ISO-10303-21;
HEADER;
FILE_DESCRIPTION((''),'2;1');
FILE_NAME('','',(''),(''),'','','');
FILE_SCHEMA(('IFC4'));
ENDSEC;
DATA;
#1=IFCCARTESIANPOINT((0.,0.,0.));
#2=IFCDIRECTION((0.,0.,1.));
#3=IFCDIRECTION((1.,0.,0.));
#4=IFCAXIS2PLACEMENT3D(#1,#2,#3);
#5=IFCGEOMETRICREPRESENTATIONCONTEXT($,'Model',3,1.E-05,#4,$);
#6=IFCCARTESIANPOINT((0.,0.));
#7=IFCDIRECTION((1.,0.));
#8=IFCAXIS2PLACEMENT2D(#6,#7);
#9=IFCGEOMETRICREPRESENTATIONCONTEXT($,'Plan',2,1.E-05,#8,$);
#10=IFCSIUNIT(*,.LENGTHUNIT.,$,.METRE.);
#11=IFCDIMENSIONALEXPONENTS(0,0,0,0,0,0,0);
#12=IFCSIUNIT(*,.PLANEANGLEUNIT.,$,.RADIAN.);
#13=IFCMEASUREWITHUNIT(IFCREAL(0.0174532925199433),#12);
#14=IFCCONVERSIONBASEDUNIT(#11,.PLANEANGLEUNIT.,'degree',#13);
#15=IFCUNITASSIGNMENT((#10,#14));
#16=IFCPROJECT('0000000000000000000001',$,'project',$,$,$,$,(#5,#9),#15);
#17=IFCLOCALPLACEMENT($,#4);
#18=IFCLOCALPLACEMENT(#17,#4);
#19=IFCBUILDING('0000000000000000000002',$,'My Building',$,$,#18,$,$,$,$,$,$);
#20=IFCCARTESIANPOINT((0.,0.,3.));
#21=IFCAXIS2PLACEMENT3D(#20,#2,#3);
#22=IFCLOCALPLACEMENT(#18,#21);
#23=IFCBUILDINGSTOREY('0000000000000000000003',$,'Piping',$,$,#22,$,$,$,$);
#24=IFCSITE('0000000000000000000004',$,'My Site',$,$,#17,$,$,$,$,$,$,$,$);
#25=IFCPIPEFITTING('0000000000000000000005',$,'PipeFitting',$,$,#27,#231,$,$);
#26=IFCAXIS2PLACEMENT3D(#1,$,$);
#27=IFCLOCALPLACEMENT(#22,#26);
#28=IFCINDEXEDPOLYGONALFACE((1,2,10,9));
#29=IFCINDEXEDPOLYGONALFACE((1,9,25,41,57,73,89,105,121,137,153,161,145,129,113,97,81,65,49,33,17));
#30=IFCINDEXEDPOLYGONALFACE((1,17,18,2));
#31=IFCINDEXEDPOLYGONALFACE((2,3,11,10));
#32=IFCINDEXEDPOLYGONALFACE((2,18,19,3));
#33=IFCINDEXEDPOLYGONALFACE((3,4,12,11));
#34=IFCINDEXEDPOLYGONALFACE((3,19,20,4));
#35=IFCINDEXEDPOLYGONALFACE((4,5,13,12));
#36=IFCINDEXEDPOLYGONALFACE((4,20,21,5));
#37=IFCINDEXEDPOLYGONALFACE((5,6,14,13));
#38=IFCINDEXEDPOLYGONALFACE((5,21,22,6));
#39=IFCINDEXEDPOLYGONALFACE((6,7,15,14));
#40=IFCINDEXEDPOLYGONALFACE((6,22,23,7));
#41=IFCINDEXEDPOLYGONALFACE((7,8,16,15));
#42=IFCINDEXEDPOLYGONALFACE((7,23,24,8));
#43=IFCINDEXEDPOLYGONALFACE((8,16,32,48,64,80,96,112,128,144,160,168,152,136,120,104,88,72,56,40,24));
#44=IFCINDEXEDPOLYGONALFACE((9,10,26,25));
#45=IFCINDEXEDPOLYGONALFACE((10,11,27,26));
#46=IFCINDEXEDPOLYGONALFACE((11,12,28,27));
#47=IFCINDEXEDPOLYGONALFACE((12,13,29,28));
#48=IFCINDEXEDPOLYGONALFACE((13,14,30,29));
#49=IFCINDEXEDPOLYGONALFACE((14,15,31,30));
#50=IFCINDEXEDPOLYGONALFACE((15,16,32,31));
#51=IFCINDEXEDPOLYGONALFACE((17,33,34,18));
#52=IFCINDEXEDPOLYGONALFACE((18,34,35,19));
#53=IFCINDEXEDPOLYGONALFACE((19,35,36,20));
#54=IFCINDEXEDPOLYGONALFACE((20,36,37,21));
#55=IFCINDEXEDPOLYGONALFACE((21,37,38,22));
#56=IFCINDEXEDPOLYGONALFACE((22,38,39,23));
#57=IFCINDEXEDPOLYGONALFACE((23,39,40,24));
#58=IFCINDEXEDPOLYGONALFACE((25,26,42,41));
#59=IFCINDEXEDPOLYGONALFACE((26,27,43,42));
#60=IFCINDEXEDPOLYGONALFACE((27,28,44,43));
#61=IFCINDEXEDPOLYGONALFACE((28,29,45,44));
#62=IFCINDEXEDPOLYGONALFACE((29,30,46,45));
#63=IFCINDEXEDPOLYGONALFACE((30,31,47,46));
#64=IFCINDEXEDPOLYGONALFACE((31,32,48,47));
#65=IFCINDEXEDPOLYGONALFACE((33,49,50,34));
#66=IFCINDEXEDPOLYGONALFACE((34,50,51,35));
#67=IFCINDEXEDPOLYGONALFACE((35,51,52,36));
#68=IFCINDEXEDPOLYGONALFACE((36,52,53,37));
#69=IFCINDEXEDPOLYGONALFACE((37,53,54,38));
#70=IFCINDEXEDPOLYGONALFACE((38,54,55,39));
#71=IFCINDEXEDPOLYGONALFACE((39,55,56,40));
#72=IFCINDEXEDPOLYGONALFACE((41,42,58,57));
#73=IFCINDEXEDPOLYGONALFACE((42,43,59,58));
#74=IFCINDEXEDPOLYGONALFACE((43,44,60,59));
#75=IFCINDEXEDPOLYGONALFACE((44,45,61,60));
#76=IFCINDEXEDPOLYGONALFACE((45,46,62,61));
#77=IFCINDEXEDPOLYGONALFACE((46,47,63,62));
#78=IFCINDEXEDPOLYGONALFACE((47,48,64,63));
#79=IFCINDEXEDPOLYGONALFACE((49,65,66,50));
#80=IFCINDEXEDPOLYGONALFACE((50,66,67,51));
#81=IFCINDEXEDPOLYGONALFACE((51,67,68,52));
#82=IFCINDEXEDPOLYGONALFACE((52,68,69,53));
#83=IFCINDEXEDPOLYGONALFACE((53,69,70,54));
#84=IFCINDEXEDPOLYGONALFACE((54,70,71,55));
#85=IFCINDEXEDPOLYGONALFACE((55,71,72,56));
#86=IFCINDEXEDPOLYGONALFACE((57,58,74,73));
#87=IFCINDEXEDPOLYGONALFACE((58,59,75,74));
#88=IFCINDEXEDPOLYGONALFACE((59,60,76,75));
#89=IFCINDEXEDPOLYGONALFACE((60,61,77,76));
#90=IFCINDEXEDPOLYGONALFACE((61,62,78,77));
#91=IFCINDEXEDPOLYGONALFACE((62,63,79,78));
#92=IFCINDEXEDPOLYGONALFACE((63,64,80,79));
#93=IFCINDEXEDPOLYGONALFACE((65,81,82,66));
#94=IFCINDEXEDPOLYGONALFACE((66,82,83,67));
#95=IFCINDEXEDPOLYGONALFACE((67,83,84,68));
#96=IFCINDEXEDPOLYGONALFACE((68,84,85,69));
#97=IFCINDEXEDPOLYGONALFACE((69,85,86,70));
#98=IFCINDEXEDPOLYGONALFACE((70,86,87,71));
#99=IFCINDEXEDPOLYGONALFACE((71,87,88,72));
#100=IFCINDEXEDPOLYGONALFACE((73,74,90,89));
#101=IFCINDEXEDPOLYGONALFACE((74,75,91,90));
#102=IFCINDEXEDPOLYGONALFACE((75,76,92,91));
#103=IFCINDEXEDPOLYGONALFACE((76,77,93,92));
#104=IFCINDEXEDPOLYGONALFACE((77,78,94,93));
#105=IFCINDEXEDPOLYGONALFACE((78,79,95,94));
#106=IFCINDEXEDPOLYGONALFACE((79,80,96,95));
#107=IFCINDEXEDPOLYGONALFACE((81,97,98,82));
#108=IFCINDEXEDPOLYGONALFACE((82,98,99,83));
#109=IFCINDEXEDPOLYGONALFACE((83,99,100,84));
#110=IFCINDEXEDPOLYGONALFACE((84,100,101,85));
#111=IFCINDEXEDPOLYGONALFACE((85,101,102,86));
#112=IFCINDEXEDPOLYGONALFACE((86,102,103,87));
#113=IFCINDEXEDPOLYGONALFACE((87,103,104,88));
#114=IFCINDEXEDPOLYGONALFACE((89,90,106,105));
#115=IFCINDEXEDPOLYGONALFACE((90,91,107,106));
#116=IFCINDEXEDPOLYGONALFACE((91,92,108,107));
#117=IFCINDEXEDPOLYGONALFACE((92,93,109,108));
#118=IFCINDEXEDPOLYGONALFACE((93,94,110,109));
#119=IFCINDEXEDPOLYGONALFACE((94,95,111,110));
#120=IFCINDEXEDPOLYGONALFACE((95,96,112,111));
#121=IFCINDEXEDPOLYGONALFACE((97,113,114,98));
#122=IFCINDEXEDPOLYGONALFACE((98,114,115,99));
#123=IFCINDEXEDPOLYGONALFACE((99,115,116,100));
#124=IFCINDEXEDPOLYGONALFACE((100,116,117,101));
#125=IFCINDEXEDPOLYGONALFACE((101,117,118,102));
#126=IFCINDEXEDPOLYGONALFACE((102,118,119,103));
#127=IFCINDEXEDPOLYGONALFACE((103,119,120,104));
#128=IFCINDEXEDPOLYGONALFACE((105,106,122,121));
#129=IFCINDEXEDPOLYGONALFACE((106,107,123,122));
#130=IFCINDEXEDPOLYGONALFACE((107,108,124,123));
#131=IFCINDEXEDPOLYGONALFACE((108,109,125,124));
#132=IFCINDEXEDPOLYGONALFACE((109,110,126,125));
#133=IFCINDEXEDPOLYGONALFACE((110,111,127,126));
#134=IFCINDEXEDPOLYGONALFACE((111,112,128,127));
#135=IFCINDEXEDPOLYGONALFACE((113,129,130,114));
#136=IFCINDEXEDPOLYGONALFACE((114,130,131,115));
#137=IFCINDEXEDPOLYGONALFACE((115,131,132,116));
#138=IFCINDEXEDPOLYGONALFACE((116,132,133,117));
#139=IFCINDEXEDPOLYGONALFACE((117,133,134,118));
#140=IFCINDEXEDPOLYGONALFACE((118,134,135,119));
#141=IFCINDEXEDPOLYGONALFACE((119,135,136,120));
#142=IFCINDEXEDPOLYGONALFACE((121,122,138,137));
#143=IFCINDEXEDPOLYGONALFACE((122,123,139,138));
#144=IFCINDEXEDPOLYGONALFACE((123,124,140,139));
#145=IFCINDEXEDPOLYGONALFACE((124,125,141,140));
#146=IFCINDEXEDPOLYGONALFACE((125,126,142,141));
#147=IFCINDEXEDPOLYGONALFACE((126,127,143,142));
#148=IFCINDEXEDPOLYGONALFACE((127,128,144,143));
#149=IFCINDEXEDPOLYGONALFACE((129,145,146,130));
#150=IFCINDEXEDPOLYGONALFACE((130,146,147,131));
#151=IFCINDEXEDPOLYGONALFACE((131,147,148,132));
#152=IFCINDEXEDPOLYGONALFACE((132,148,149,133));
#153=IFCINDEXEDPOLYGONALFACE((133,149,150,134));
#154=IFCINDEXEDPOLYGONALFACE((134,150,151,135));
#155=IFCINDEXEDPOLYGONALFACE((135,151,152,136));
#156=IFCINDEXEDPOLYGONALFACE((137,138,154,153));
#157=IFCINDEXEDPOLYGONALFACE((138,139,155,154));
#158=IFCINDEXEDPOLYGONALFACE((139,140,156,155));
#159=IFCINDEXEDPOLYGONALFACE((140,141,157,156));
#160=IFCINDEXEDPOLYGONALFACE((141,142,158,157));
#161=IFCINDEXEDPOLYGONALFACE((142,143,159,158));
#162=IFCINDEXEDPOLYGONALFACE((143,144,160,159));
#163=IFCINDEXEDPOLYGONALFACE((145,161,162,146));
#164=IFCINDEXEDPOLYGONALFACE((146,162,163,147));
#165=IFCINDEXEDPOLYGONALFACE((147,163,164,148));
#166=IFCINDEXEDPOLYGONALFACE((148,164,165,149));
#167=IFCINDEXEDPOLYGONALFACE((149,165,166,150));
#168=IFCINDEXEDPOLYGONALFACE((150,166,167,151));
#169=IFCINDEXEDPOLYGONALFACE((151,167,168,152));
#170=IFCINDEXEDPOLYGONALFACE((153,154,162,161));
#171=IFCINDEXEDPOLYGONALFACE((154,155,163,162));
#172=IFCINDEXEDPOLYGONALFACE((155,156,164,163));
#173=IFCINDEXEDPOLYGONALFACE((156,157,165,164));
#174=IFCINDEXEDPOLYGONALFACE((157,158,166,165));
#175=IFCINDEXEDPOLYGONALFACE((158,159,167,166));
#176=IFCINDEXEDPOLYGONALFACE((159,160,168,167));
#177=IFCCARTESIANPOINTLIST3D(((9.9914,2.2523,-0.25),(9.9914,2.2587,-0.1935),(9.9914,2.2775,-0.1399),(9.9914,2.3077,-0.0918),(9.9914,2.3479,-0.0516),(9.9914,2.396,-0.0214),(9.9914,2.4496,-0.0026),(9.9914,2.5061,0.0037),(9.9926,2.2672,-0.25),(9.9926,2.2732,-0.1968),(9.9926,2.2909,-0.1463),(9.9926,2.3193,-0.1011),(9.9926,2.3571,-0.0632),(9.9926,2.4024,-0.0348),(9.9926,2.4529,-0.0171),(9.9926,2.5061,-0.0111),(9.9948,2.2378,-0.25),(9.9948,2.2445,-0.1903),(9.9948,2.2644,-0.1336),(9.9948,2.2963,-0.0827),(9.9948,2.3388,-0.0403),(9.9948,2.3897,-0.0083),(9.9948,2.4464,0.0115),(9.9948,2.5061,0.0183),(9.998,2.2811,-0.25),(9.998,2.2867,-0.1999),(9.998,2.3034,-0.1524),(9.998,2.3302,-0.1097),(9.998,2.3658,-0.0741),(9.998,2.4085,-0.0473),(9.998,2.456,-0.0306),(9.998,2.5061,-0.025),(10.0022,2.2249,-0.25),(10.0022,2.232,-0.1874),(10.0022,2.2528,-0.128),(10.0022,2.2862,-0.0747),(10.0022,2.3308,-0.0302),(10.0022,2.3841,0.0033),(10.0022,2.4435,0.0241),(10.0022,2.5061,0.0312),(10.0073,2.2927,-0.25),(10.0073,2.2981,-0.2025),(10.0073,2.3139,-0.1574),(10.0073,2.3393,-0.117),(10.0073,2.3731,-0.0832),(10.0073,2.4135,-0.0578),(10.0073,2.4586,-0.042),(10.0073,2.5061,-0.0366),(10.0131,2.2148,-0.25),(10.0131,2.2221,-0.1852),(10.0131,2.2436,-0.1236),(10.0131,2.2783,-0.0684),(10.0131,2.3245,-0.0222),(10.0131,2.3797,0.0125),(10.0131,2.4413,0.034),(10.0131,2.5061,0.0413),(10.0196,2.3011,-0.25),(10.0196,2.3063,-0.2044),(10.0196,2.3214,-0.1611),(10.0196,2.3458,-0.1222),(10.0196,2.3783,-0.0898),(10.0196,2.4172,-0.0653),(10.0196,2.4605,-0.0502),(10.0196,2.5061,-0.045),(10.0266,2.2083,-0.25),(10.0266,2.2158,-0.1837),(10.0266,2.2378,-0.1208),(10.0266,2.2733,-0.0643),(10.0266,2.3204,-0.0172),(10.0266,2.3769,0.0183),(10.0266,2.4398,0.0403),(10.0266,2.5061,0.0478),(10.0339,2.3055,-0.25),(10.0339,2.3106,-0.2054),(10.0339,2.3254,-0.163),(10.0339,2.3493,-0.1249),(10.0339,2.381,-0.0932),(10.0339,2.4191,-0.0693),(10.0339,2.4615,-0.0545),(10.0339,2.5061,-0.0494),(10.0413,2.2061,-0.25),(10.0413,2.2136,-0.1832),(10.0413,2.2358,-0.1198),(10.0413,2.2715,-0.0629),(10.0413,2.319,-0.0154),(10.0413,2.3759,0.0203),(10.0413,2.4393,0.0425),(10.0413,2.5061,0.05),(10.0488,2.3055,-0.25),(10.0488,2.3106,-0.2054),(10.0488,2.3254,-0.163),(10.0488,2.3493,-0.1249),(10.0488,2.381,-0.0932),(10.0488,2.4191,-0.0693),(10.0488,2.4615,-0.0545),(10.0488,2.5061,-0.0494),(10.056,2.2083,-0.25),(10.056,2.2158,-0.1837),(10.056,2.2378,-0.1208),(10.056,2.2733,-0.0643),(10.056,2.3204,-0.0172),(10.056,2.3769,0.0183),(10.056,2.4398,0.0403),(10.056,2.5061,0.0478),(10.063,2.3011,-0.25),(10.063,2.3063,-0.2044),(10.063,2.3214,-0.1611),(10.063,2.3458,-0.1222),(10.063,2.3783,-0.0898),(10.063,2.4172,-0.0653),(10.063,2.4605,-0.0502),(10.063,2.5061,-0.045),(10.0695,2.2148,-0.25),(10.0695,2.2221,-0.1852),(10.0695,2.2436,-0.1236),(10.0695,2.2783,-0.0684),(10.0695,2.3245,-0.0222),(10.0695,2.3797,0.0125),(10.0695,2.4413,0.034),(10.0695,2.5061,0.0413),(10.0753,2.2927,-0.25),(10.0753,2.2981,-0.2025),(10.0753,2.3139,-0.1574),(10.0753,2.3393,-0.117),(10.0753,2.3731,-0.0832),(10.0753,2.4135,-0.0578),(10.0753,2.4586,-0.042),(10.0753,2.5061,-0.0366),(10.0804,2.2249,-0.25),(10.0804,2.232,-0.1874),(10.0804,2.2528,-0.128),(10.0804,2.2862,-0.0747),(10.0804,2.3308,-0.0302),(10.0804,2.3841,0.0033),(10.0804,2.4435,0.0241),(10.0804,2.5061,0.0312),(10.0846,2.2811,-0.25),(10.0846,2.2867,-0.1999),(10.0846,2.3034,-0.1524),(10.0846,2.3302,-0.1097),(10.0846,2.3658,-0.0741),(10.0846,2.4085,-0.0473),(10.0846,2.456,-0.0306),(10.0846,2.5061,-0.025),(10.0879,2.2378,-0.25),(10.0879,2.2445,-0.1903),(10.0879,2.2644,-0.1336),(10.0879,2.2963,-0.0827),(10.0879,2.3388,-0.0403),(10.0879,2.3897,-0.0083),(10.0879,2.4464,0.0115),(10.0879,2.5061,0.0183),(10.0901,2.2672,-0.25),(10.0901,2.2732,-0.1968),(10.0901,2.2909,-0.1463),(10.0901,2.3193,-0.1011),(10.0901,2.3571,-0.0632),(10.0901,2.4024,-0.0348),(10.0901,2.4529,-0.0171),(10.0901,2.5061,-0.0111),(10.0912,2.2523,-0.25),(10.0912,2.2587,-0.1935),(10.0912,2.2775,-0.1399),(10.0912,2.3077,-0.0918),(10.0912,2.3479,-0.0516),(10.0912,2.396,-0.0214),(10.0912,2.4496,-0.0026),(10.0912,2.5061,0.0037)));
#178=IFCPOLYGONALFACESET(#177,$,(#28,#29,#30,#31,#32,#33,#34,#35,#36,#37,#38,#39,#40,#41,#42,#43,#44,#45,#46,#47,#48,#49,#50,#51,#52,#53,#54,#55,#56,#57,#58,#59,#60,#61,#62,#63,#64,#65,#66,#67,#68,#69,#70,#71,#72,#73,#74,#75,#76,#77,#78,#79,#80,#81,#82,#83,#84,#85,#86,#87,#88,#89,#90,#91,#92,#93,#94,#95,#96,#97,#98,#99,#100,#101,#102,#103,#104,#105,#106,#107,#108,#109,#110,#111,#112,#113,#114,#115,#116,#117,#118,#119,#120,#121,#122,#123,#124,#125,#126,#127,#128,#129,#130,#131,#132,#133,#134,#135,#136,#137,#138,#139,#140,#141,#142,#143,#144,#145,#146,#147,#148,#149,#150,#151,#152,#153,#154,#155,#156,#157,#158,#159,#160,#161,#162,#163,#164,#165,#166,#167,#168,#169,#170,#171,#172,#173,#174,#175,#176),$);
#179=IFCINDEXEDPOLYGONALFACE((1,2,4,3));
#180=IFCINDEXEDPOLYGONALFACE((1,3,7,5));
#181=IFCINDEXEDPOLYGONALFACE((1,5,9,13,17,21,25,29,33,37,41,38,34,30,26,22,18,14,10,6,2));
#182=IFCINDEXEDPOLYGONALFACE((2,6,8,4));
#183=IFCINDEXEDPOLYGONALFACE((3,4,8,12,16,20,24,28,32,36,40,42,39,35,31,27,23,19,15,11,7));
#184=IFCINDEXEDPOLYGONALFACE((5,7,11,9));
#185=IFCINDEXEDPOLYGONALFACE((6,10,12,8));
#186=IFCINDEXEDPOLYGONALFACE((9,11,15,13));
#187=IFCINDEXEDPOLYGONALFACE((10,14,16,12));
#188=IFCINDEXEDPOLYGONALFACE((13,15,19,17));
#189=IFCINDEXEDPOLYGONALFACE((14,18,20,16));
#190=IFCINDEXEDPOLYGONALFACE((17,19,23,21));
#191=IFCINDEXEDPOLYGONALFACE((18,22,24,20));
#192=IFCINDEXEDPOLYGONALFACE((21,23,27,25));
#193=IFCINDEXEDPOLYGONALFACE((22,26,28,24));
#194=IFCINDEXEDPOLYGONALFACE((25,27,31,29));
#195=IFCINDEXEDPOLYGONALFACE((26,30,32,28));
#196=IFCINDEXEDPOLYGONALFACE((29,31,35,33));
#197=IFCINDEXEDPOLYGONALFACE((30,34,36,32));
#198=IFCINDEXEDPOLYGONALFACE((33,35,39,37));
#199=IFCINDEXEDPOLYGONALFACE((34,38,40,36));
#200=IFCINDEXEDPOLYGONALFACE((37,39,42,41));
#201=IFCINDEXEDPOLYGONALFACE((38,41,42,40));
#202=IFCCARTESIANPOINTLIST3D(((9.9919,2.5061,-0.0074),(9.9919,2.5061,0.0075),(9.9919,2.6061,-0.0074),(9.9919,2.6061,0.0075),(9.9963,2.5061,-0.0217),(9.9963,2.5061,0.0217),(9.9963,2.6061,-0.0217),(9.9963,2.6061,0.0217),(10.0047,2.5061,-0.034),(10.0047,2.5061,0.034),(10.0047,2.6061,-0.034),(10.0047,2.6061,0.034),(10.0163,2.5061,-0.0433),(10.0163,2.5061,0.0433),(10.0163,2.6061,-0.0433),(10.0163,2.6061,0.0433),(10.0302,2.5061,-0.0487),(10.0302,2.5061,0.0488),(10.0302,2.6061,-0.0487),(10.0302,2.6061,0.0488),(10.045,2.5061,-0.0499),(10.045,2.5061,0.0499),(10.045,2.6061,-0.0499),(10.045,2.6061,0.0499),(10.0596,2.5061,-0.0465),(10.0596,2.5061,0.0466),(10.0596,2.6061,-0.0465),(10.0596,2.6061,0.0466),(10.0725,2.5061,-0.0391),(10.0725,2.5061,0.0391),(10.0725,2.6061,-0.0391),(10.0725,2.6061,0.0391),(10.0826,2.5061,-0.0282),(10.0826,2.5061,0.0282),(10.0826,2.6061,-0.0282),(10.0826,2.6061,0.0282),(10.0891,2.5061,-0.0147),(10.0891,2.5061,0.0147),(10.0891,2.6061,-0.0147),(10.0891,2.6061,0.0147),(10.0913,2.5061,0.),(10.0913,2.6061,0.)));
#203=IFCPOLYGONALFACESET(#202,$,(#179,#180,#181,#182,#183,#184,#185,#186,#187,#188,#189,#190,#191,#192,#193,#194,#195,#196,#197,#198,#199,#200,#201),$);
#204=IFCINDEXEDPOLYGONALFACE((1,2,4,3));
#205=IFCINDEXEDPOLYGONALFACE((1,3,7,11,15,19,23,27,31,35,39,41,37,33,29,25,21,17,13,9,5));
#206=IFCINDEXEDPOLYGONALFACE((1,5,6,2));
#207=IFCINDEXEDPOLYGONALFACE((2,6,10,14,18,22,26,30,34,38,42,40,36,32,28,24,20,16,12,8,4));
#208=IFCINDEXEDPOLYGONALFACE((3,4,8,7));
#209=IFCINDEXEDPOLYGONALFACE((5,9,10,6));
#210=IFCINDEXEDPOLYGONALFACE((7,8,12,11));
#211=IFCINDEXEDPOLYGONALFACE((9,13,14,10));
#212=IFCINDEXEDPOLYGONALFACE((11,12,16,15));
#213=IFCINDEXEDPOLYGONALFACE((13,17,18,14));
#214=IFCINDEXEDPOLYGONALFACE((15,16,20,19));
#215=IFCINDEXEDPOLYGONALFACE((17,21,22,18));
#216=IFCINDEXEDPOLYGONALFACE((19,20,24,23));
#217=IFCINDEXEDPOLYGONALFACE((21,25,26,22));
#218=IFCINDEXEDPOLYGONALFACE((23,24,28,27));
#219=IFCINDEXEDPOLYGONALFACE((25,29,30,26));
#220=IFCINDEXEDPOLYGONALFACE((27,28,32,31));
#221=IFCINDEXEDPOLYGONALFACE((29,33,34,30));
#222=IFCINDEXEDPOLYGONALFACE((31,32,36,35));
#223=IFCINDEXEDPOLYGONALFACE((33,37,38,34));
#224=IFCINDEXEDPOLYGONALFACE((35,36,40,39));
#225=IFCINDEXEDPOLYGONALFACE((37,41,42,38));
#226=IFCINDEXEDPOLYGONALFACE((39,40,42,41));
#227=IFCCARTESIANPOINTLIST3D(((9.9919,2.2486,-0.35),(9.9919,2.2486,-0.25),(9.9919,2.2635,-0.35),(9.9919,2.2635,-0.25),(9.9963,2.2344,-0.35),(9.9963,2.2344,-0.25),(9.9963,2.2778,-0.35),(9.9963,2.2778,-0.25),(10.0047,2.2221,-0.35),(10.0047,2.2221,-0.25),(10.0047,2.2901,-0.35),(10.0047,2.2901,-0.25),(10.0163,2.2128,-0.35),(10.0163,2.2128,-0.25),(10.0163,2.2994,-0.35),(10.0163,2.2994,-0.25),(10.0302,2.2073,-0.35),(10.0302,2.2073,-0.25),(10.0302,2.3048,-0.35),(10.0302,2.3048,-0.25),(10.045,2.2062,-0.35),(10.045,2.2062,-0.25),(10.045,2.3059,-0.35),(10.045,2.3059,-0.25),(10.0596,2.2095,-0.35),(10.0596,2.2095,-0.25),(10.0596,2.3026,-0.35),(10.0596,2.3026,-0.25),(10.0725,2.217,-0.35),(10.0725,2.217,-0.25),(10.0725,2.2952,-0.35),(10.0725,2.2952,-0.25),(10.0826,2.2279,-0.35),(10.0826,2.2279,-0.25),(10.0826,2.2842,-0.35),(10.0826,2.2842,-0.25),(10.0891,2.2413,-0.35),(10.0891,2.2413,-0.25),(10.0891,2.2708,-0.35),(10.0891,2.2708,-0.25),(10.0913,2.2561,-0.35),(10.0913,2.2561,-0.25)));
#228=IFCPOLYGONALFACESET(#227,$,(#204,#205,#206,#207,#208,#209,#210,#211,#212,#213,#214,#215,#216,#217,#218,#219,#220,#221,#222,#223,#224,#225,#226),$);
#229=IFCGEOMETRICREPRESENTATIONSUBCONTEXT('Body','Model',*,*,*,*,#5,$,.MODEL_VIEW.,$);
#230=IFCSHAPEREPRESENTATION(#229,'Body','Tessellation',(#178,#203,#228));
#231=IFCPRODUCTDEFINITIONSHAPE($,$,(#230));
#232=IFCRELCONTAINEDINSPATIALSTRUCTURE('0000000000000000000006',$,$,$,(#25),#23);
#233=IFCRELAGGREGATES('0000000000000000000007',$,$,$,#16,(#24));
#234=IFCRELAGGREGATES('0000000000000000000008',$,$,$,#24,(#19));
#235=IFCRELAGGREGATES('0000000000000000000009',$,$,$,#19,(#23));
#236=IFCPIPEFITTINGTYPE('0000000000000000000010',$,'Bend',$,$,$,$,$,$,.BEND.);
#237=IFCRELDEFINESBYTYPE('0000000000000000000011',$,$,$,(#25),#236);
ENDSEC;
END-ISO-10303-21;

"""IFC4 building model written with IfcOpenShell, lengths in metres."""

from ifc_helpers import new_model, entity, si_unit, converted_unit, frame, origin_with_axes, origin_2d_with_axis, place, context, subcontext, project, spatial, circle, extrude, source, transform, mapped, type_object, type_shapes, element, save


model = new_model("IFC4")

# Units and contexts
model_context = context("Model", 3, precision=1e-05, world=origin_with_axes())
plan_context = context("Plan", 2, precision=1e-05, world=origin_2d_with_axis())
body_context = subcontext(model_context, "Body", "Model", "MODEL_VIEW")
ifc_project = project(units=[si_unit("LENGTHUNIT", "METRE"), converted_unit("PLANEANGLEUNIT", "degree", entity("IfcReal", 0.0174532925199433), si_unit("PLANEANGLEUNIT", "RADIAN"), dimensions=[0, 0, 0, 0, 0, 0, 0])], contexts=[model_context, plan_context])

# Site, building, storey
site_placement = place(None, origin_with_axes())
site = spatial("IfcSite", under=ifc_project, at=site_placement, Name="My Site")
building_placement = place(site_placement, origin_with_axes())
building = spatial("IfcBuilding", under=site, at=building_placement, Name="My Building")
storey_placement = place(building_placement, frame((0.0, 0.0, 3.0), z_axis=(0.0, 0.0, 1.0), x_axis=(1.0, 0.0, 0.0)))
storey = spatial("IfcBuildingStorey", under=building, at=storey_placement, Name="Piping")

# Pipe fitting
pipe_fitting_type = type_object("IfcPipeFittingType", Name="Bend", PredefinedType="BEND")
shared_shape = source(origin_with_axes(), body_context, "Body", "SolidModel", [
    entity("IfcSweptDiskSolid", entity("IfcIndexedPolyCurve", entity("IfcCartesianPointList3D", [[0.0, 0.0, 0.1], [0.0, -0.0732, 0.2768], [0.0, -0.25, 0.35]]), [entity("IfcArcIndex", [1, 2, 3])]), 0.05),
    extrude(circle(Radius=0.05), origin_with_axes(), (0.0, 0.0, 1.0), 0.1),
    extrude(circle(Radius=0.05), frame((0.0, -0.25, 0.35), z_axis=(0.0, -1.0, 0.0), x_axis=(1.0, 0.0, 0.0)), (0.0, 0.0, 1.0), 0.1),
])
type_shapes(pipe_fitting_type, [shared_shape])
for number, where, z_axis, x_axis, name in (
    (1, (10.0413, 2.6061, 0.0), (0.0, -1.0, 0.0), (1.0, 0.0, 0.0), "PipeFitting"),
):
    element("IfcPipeFitting", number, at=place(storey_placement, frame(where, z_axis=z_axis, x_axis=x_axis)), inside=storey, type_object=pipe_fitting_type, Name=name, context=body_context, shape_type="MappedRepresentation", body=[
        mapped(shared_shape, transform((0.0, 0.0, 0.0), x_axis=(1.0, 0.0, 0.0), y_axis=(0.0, 1.0, 0.0), z_axis=(0.0, 0.0, 1.0), scale=1.0)),
    ])

save(model, "model.ifc")
